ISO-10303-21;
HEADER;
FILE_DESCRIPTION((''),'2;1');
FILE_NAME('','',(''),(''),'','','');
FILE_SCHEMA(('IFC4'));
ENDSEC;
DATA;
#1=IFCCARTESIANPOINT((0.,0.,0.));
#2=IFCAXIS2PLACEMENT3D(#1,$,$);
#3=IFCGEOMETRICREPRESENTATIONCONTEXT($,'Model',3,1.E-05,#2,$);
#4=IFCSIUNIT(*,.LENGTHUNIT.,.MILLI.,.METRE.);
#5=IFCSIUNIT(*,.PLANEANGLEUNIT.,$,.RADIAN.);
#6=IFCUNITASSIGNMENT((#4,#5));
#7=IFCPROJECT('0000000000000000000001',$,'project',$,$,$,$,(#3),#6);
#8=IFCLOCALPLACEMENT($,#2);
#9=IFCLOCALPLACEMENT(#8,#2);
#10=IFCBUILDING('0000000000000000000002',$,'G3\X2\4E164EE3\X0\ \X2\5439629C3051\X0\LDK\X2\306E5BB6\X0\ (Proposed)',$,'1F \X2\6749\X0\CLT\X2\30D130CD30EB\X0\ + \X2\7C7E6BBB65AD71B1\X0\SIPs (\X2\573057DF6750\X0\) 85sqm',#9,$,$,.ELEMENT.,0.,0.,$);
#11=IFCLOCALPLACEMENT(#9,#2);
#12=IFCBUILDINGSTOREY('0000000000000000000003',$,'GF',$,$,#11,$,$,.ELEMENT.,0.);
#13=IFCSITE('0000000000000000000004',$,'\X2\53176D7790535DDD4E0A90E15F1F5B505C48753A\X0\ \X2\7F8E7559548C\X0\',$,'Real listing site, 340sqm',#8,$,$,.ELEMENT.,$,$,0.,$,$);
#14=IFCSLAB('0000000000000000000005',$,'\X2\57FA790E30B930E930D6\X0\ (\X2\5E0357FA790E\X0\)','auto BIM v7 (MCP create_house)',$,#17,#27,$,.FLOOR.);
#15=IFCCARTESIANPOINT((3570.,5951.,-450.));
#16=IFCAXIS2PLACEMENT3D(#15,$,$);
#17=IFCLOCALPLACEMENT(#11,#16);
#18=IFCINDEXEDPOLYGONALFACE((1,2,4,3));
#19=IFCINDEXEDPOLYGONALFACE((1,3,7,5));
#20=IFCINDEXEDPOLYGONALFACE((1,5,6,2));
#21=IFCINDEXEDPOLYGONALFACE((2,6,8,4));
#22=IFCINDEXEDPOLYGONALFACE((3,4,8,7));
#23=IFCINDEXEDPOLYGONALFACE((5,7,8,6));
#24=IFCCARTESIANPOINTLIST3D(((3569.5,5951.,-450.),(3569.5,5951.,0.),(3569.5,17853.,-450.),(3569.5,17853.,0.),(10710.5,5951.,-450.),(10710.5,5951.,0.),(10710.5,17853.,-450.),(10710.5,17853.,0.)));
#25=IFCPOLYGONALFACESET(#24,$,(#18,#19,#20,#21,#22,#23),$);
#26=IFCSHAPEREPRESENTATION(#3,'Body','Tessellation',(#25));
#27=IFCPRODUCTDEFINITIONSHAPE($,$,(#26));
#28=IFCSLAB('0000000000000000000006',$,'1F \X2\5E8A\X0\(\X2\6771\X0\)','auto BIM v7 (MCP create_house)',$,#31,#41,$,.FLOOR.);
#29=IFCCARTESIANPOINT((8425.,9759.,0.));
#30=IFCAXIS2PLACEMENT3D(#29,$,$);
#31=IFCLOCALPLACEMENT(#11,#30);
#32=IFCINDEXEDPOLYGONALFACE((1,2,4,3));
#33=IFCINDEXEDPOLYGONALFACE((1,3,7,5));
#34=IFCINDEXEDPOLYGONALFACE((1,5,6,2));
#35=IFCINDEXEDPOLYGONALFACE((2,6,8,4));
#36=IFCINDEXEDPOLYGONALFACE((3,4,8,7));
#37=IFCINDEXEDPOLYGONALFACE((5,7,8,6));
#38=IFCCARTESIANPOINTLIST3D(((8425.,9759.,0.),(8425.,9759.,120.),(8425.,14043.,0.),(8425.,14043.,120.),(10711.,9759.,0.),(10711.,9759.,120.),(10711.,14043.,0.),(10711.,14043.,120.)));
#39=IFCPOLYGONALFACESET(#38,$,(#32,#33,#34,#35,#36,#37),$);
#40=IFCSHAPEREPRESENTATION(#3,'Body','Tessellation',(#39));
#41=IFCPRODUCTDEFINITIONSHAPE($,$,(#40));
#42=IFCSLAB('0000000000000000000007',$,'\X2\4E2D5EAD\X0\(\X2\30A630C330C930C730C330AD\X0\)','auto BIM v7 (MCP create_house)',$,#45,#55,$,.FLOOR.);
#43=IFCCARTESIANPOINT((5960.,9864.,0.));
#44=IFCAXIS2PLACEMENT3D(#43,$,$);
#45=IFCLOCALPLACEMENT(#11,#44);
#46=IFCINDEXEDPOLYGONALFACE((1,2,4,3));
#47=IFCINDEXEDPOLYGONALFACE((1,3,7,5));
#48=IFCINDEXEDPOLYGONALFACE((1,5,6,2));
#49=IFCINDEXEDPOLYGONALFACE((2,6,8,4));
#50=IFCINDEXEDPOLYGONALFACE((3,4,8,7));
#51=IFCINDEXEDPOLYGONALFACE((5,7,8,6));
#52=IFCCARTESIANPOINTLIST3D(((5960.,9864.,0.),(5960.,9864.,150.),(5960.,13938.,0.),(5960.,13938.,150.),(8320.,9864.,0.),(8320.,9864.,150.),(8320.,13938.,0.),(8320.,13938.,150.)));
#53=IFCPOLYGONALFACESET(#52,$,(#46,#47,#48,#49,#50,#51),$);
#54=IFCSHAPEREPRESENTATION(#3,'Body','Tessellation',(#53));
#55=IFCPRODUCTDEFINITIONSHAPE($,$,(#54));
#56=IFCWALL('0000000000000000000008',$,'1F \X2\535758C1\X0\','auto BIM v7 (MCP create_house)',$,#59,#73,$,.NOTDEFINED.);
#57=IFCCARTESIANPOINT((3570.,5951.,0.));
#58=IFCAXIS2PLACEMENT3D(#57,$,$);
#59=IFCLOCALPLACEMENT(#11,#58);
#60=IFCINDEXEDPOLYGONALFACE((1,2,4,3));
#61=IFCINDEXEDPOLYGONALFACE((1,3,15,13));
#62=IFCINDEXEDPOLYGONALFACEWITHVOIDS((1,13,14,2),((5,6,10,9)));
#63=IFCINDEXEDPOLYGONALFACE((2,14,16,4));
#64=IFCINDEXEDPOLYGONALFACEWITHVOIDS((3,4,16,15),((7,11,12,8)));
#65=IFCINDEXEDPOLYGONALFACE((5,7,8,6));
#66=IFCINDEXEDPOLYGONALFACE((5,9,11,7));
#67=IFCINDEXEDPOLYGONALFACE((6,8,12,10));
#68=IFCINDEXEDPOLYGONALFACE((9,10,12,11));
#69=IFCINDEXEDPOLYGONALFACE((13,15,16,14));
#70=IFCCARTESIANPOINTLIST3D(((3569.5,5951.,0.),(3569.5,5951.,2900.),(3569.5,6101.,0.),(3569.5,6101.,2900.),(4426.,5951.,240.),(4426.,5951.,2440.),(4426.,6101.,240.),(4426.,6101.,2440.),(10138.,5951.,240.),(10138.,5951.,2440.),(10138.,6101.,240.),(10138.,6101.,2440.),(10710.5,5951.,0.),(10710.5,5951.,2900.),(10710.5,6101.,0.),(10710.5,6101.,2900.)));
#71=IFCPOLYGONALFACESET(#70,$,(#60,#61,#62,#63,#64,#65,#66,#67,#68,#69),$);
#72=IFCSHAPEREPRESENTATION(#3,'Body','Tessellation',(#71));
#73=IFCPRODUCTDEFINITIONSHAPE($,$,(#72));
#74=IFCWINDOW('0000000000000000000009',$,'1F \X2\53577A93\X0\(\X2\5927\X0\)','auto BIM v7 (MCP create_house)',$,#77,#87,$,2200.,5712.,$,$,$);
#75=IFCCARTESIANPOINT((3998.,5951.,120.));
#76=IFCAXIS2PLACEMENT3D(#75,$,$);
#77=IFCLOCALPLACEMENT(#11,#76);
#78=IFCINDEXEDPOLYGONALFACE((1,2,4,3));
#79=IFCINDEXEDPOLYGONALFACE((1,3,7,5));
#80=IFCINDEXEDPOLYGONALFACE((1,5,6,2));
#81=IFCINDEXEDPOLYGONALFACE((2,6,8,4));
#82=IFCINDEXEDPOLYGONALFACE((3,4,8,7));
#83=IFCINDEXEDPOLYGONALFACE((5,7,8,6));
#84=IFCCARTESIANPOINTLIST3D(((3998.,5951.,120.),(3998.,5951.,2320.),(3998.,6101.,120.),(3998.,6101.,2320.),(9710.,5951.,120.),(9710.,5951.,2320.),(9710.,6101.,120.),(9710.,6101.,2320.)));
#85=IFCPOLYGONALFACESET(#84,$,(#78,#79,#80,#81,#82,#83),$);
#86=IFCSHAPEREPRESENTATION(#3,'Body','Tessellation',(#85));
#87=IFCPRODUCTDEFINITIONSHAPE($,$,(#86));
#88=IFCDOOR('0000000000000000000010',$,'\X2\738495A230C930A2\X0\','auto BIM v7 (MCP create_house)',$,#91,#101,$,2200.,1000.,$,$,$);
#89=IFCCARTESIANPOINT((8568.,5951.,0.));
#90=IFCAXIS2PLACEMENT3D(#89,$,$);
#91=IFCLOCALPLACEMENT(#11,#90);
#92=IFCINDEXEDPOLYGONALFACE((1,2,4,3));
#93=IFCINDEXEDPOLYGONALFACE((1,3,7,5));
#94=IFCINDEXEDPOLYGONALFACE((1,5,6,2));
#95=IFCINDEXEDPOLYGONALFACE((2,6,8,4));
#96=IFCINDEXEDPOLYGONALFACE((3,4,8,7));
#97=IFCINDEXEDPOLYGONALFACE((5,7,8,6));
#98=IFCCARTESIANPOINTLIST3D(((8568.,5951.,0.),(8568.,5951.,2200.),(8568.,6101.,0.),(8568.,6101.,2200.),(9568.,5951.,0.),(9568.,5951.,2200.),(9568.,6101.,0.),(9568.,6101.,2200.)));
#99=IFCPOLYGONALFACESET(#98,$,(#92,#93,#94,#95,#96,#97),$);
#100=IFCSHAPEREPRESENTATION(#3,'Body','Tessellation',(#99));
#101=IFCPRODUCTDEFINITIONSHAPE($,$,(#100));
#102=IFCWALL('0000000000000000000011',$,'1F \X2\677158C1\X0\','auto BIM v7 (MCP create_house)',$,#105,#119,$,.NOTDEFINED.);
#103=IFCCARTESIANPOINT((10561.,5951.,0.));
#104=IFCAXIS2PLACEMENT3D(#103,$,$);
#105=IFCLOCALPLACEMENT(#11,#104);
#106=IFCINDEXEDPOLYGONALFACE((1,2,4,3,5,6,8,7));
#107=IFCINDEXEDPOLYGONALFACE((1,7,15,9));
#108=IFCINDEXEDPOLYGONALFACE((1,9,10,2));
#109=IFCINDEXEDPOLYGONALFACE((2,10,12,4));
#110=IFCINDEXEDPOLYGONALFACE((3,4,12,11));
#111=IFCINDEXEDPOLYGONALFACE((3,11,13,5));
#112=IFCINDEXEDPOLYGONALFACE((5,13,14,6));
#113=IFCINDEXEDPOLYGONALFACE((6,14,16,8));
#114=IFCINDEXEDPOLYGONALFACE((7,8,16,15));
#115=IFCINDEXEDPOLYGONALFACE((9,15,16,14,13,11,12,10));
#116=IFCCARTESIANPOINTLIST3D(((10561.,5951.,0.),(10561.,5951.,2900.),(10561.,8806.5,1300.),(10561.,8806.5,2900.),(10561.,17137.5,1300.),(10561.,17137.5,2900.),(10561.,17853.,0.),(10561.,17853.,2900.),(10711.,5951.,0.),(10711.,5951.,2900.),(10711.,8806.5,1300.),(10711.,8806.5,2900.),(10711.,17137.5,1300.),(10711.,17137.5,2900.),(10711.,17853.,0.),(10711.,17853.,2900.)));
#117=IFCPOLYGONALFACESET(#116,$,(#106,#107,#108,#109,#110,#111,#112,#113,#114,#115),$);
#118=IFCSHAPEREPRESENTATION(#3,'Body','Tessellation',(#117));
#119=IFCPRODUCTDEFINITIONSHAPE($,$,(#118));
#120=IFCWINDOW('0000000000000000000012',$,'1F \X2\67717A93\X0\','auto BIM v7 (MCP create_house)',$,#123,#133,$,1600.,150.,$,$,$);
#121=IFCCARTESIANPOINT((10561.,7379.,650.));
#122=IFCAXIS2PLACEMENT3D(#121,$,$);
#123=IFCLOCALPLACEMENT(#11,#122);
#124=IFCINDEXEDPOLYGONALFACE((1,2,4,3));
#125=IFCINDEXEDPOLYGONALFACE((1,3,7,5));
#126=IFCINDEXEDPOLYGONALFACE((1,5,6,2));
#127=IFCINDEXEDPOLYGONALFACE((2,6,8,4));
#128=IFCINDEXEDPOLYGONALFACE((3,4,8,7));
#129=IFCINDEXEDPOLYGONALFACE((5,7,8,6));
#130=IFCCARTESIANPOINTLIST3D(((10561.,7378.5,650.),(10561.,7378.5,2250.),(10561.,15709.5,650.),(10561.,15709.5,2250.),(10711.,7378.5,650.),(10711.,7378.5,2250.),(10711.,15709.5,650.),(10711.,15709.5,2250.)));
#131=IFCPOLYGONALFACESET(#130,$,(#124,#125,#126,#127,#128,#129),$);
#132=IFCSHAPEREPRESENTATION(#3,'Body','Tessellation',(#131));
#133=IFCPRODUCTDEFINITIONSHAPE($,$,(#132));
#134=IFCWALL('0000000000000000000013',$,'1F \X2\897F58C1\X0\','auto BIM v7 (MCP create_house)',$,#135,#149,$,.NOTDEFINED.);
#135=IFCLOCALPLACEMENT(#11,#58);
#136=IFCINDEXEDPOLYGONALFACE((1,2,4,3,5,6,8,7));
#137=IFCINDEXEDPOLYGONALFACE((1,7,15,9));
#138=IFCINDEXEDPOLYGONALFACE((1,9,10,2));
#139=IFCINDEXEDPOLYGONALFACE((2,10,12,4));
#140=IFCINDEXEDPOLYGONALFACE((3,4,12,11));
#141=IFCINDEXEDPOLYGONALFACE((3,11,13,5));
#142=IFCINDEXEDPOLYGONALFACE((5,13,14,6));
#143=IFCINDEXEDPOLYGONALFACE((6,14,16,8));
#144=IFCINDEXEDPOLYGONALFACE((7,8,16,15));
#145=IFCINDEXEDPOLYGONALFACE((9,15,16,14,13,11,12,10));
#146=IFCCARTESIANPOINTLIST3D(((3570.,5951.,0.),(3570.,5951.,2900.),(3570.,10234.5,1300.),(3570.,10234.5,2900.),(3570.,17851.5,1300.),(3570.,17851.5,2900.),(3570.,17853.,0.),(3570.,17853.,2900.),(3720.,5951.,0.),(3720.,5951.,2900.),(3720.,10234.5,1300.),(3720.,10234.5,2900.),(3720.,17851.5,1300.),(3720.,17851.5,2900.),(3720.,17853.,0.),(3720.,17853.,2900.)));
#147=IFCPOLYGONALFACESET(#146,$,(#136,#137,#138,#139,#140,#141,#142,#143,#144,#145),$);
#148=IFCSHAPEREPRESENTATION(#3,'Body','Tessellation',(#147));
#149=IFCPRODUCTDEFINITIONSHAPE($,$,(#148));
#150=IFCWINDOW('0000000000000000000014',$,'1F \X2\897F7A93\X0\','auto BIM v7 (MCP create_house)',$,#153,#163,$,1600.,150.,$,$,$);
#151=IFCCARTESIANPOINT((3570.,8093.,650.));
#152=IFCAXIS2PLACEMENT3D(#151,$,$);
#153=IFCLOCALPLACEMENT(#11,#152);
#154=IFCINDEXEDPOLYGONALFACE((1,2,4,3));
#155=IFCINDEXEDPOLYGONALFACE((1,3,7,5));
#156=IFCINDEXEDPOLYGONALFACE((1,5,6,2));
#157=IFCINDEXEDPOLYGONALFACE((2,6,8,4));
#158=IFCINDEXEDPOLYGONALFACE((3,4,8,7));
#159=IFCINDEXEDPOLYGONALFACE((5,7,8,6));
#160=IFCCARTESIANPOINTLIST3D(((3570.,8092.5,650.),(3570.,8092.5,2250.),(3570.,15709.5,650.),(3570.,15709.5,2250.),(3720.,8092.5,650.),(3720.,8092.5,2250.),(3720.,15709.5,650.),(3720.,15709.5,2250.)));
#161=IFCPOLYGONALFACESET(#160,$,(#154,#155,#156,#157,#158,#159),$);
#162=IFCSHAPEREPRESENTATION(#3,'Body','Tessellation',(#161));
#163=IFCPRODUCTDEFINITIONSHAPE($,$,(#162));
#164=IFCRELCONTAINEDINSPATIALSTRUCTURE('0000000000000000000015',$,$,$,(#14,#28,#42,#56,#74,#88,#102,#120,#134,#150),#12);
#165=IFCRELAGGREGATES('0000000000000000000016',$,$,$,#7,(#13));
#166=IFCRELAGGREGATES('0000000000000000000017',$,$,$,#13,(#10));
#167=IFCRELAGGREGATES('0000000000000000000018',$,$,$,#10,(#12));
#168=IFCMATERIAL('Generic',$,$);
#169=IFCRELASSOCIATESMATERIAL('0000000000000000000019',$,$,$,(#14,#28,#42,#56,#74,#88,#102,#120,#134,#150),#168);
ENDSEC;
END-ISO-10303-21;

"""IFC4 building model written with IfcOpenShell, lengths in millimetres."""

from ifc_helpers import new_model, si_unit, frame, frame_2d, origin, place, context, project, spatial, rectangle, extrude, material, element, fill, save


model = new_model("IFC4")

# Units and contexts
model_context = context("Model", 3, precision=1e-05, world=origin())
ifc_project = project(units=[si_unit("LENGTHUNIT", "METRE", prefix="MILLI"), si_unit("PLANEANGLEUNIT", "RADIAN")], contexts=[model_context])

# Site, building, storey
site_placement = place(None, origin())
site = spatial("IfcSite", under=ifc_project, at=site_placement, Name="北海道川上郡弟子屈町 美留和", ObjectType="Real listing site, 340sqm", CompositionType="ELEMENT", RefElevation=0.0)
building_placement = place(site_placement, origin())
building = spatial("IfcBuilding", under=site, at=building_placement, Name="G3世代 吹抜けLDKの家 (Proposed)", ObjectType="1F 杉CLTパネル + 籾殻断熱SIPs (地域材) 85sqm", CompositionType="ELEMENT", ElevationOfRefHeight=0.0, ElevationOfTerrain=0.0)
storey_placement = place(building_placement, origin())
storey = spatial("IfcBuildingStorey", under=building, at=storey_placement, Name="GF", CompositionType="ELEMENT", Elevation=0.0)

# Slabs
ifc_material = material(Name="Generic")
slab_1_placement = place(storey_placement, frame((3570.0, 5951.0, -450.0)))
element("IfcSlab", 1, at=slab_1_placement, inside=storey, material=ifc_material, Name="基礎スラブ (布基礎)", Description="auto BIM v7 (MCP create_house)", PredefinedType="FLOOR", context=model_context, shape_type="SweptSolid", body=[
    extrude(rectangle(XDim=7141.0, YDim=11902.0, at=frame_2d((3570.0, 5951.0))), frame((3570.0, 5951.0, -450.0)), (0.0, 0.0, 1.0), 450.0),
])
slab_2_placement = place(storey_placement, frame((8425.0, 9759.0, 0.0)))
element("IfcSlab", 2, at=slab_2_placement, inside=storey, material=ifc_material, Name="1F 床(東)", Description="auto BIM v7 (MCP create_house)", PredefinedType="FLOOR", context=model_context, shape_type="SweptSolid", body=[
    extrude(rectangle(XDim=2286.0, YDim=4284.0, at=frame_2d((1143.0, 2142.0))), frame((8425.0, 9759.0, 0.0)), (0.0, 0.0, 1.0), 120.0),
])
slab_3_placement = place(storey_placement, frame((5960.0, 9864.0, 0.0)))
element("IfcSlab", 3, at=slab_3_placement, inside=storey, material=ifc_material, Name="中庭(ウッドデッキ)", Description="auto BIM v7 (MCP create_house)", PredefinedType="FLOOR", context=model_context, shape_type="SweptSolid", body=[
    extrude(rectangle(XDim=2360.0, YDim=4074.0, at=frame_2d((1180.0, 2037.0))), frame((5960.0, 9864.0, 0.0)), (0.0, 0.0, 1.0), 150.0),
])

# Wall, openings, window, door
wall_1_placement = place(storey_placement, frame((3570.0, 5951.0, 0.0)))
wall_1 = element("IfcWall", 4, at=wall_1_placement, inside=storey, material=ifc_material, Name="1F 南壁", Description="auto BIM v7 (MCP create_house)", PredefinedType="NOTDEFINED", context=model_context, shape_type="SweptSolid", body=[
    extrude(rectangle(XDim=7141.0, YDim=150.0, at=frame_2d((3570.0, 75.0))), frame((3570.0, 5951.0, 0.0)), (0.0, 0.0, 1.0), 2900.0),
])
opening_1_placement = place(storey_placement, frame((3998.0, 5951.0, 120.0)))
opening_1 = element("IfcOpeningElement", 5, at=opening_1_placement, cuts=wall_1, PredefinedType="NOTDEFINED", context=model_context, shape_type="SweptSolid", body=[
    extrude(rectangle(XDim=5712.0, YDim=150.0, at=frame_2d((2856.0, 75.0))), frame((3998.0, 5951.0, 120.0)), (0.0, 0.0, 1.0), 2200.0),
])
opening_2_placement = place(storey_placement, frame((8568.0, 5951.0, 0.0)))
opening_2 = element("IfcOpeningElement", 6, at=opening_2_placement, cuts=wall_1, PredefinedType="NOTDEFINED", context=model_context, shape_type="SweptSolid", body=[
    extrude(rectangle(XDim=1000.0, YDim=150.0, at=frame_2d((500.0, 75.0))), frame((8568.0, 5951.0, 0.0)), (0.0, 0.0, 1.0), 2200.0),
])
window_1_placement = place(storey_placement, frame((3998.0, 5951.0, 120.0)))
window_1 = element("IfcWindow", 7, at=window_1_placement, inside=storey, material=ifc_material, Name="1F 南窓(大)", Description="auto BIM v7 (MCP create_house)", OverallHeight=2200.0, OverallWidth=5712.0, context=model_context, shape_type="SweptSolid", body=[
    extrude(rectangle(XDim=5712.0, YDim=150.0, at=frame_2d((2856.0, 75.0))), frame((3998.0, 5951.0, 120.0)), (0.0, 0.0, 1.0), 2200.0),
])
fill(opening_1, window_1)
door_placement = place(storey_placement, frame((8568.0, 5951.0, 0.0)))
door = element("IfcDoor", 8, at=door_placement, inside=storey, material=ifc_material, Name="玄関ドア", Description="auto BIM v7 (MCP create_house)", OverallHeight=2200.0, OverallWidth=1000.0, context=model_context, shape_type="SweptSolid", body=[
    extrude(rectangle(XDim=1000.0, YDim=150.0, at=frame_2d((500.0, 75.0))), frame((8568.0, 5951.0, 0.0)), (0.0, 0.0, 1.0), 2200.0),
])
fill(opening_2, door)

# Walls, openings, windows
wall_2_placement = place(storey_placement, frame((10561.0, 5951.0, 0.0)))
wall_2 = element("IfcWall", 9, at=wall_2_placement, inside=storey, material=ifc_material, Name="1F 東壁", Description="auto BIM v7 (MCP create_house)", PredefinedType="NOTDEFINED", context=model_context, shape_type="SweptSolid", body=[
    extrude(rectangle(XDim=150.0, YDim=11902.0, at=frame_2d((75.0, 5951.0))), frame((10561.0, 5951.0, 0.0)), (0.0, 0.0, 1.0), 2900.0),
])
opening_3_placement = place(storey_placement, frame((10561.0, 7379.0, 650.0)))
opening_3 = element("IfcOpeningElement", 10, at=opening_3_placement, cuts=wall_2, PredefinedType="NOTDEFINED", context=model_context, shape_type="SweptSolid", body=[
    extrude(rectangle(XDim=150.0, YDim=8331.0, at=frame_2d((75.0, 4165.0))), frame((10561.0, 7379.0, 650.0)), (0.0, 0.0, 1.0), 1600.0),
])
window_2_placement = place(storey_placement, frame((10561.0, 7379.0, 650.0)))
window_2 = element("IfcWindow", 11, at=window_2_placement, inside=storey, material=ifc_material, Name="1F 東窓", Description="auto BIM v7 (MCP create_house)", OverallHeight=1600.0, OverallWidth=150.0, context=model_context, shape_type="SweptSolid", body=[
    extrude(rectangle(XDim=150.0, YDim=8331.0, at=frame_2d((75.0, 4165.0))), frame((10561.0, 7379.0, 650.0)), (0.0, 0.0, 1.0), 1600.0),
])
fill(opening_3, window_2)
wall_3_placement = place(storey_placement, frame((3570.0, 5951.0, 0.0)))
wall_3 = element("IfcWall", 12, at=wall_3_placement, inside=storey, material=ifc_material, Name="1F 西壁", Description="auto BIM v7 (MCP create_house)", PredefinedType="NOTDEFINED", context=model_context, shape_type="SweptSolid", body=[
    extrude(rectangle(XDim=150.0, YDim=11902.0, at=frame_2d((75.0, 5951.0))), frame((3570.0, 5951.0, 0.0)), (0.0, 0.0, 1.0), 2900.0),
])
opening_4_placement = place(storey_placement, frame((3570.0, 8093.0, 650.0)))
opening_4 = element("IfcOpeningElement", 13, at=opening_4_placement, cuts=wall_3, PredefinedType="NOTDEFINED", context=model_context, shape_type="SweptSolid", body=[
    extrude(rectangle(XDim=150.0, YDim=7617.0, at=frame_2d((75.0, 3808.0))), frame((3570.0, 8093.0, 650.0)), (0.0, 0.0, 1.0), 1600.0),
])
window_3_placement = place(storey_placement, frame((3570.0, 8093.0, 650.0)))
window_3 = element("IfcWindow", 14, at=window_3_placement, inside=storey, material=ifc_material, Name="1F 西窓", Description="auto BIM v7 (MCP create_house)", OverallHeight=1600.0, OverallWidth=150.0, context=model_context, shape_type="SweptSolid", body=[
    extrude(rectangle(XDim=150.0, YDim=7617.0, at=frame_2d((75.0, 3808.0))), frame((3570.0, 8093.0, 650.0)), (0.0, 0.0, 1.0), 1600.0),
])
fill(opening_4, window_3)

save(model, "model.ifc")
